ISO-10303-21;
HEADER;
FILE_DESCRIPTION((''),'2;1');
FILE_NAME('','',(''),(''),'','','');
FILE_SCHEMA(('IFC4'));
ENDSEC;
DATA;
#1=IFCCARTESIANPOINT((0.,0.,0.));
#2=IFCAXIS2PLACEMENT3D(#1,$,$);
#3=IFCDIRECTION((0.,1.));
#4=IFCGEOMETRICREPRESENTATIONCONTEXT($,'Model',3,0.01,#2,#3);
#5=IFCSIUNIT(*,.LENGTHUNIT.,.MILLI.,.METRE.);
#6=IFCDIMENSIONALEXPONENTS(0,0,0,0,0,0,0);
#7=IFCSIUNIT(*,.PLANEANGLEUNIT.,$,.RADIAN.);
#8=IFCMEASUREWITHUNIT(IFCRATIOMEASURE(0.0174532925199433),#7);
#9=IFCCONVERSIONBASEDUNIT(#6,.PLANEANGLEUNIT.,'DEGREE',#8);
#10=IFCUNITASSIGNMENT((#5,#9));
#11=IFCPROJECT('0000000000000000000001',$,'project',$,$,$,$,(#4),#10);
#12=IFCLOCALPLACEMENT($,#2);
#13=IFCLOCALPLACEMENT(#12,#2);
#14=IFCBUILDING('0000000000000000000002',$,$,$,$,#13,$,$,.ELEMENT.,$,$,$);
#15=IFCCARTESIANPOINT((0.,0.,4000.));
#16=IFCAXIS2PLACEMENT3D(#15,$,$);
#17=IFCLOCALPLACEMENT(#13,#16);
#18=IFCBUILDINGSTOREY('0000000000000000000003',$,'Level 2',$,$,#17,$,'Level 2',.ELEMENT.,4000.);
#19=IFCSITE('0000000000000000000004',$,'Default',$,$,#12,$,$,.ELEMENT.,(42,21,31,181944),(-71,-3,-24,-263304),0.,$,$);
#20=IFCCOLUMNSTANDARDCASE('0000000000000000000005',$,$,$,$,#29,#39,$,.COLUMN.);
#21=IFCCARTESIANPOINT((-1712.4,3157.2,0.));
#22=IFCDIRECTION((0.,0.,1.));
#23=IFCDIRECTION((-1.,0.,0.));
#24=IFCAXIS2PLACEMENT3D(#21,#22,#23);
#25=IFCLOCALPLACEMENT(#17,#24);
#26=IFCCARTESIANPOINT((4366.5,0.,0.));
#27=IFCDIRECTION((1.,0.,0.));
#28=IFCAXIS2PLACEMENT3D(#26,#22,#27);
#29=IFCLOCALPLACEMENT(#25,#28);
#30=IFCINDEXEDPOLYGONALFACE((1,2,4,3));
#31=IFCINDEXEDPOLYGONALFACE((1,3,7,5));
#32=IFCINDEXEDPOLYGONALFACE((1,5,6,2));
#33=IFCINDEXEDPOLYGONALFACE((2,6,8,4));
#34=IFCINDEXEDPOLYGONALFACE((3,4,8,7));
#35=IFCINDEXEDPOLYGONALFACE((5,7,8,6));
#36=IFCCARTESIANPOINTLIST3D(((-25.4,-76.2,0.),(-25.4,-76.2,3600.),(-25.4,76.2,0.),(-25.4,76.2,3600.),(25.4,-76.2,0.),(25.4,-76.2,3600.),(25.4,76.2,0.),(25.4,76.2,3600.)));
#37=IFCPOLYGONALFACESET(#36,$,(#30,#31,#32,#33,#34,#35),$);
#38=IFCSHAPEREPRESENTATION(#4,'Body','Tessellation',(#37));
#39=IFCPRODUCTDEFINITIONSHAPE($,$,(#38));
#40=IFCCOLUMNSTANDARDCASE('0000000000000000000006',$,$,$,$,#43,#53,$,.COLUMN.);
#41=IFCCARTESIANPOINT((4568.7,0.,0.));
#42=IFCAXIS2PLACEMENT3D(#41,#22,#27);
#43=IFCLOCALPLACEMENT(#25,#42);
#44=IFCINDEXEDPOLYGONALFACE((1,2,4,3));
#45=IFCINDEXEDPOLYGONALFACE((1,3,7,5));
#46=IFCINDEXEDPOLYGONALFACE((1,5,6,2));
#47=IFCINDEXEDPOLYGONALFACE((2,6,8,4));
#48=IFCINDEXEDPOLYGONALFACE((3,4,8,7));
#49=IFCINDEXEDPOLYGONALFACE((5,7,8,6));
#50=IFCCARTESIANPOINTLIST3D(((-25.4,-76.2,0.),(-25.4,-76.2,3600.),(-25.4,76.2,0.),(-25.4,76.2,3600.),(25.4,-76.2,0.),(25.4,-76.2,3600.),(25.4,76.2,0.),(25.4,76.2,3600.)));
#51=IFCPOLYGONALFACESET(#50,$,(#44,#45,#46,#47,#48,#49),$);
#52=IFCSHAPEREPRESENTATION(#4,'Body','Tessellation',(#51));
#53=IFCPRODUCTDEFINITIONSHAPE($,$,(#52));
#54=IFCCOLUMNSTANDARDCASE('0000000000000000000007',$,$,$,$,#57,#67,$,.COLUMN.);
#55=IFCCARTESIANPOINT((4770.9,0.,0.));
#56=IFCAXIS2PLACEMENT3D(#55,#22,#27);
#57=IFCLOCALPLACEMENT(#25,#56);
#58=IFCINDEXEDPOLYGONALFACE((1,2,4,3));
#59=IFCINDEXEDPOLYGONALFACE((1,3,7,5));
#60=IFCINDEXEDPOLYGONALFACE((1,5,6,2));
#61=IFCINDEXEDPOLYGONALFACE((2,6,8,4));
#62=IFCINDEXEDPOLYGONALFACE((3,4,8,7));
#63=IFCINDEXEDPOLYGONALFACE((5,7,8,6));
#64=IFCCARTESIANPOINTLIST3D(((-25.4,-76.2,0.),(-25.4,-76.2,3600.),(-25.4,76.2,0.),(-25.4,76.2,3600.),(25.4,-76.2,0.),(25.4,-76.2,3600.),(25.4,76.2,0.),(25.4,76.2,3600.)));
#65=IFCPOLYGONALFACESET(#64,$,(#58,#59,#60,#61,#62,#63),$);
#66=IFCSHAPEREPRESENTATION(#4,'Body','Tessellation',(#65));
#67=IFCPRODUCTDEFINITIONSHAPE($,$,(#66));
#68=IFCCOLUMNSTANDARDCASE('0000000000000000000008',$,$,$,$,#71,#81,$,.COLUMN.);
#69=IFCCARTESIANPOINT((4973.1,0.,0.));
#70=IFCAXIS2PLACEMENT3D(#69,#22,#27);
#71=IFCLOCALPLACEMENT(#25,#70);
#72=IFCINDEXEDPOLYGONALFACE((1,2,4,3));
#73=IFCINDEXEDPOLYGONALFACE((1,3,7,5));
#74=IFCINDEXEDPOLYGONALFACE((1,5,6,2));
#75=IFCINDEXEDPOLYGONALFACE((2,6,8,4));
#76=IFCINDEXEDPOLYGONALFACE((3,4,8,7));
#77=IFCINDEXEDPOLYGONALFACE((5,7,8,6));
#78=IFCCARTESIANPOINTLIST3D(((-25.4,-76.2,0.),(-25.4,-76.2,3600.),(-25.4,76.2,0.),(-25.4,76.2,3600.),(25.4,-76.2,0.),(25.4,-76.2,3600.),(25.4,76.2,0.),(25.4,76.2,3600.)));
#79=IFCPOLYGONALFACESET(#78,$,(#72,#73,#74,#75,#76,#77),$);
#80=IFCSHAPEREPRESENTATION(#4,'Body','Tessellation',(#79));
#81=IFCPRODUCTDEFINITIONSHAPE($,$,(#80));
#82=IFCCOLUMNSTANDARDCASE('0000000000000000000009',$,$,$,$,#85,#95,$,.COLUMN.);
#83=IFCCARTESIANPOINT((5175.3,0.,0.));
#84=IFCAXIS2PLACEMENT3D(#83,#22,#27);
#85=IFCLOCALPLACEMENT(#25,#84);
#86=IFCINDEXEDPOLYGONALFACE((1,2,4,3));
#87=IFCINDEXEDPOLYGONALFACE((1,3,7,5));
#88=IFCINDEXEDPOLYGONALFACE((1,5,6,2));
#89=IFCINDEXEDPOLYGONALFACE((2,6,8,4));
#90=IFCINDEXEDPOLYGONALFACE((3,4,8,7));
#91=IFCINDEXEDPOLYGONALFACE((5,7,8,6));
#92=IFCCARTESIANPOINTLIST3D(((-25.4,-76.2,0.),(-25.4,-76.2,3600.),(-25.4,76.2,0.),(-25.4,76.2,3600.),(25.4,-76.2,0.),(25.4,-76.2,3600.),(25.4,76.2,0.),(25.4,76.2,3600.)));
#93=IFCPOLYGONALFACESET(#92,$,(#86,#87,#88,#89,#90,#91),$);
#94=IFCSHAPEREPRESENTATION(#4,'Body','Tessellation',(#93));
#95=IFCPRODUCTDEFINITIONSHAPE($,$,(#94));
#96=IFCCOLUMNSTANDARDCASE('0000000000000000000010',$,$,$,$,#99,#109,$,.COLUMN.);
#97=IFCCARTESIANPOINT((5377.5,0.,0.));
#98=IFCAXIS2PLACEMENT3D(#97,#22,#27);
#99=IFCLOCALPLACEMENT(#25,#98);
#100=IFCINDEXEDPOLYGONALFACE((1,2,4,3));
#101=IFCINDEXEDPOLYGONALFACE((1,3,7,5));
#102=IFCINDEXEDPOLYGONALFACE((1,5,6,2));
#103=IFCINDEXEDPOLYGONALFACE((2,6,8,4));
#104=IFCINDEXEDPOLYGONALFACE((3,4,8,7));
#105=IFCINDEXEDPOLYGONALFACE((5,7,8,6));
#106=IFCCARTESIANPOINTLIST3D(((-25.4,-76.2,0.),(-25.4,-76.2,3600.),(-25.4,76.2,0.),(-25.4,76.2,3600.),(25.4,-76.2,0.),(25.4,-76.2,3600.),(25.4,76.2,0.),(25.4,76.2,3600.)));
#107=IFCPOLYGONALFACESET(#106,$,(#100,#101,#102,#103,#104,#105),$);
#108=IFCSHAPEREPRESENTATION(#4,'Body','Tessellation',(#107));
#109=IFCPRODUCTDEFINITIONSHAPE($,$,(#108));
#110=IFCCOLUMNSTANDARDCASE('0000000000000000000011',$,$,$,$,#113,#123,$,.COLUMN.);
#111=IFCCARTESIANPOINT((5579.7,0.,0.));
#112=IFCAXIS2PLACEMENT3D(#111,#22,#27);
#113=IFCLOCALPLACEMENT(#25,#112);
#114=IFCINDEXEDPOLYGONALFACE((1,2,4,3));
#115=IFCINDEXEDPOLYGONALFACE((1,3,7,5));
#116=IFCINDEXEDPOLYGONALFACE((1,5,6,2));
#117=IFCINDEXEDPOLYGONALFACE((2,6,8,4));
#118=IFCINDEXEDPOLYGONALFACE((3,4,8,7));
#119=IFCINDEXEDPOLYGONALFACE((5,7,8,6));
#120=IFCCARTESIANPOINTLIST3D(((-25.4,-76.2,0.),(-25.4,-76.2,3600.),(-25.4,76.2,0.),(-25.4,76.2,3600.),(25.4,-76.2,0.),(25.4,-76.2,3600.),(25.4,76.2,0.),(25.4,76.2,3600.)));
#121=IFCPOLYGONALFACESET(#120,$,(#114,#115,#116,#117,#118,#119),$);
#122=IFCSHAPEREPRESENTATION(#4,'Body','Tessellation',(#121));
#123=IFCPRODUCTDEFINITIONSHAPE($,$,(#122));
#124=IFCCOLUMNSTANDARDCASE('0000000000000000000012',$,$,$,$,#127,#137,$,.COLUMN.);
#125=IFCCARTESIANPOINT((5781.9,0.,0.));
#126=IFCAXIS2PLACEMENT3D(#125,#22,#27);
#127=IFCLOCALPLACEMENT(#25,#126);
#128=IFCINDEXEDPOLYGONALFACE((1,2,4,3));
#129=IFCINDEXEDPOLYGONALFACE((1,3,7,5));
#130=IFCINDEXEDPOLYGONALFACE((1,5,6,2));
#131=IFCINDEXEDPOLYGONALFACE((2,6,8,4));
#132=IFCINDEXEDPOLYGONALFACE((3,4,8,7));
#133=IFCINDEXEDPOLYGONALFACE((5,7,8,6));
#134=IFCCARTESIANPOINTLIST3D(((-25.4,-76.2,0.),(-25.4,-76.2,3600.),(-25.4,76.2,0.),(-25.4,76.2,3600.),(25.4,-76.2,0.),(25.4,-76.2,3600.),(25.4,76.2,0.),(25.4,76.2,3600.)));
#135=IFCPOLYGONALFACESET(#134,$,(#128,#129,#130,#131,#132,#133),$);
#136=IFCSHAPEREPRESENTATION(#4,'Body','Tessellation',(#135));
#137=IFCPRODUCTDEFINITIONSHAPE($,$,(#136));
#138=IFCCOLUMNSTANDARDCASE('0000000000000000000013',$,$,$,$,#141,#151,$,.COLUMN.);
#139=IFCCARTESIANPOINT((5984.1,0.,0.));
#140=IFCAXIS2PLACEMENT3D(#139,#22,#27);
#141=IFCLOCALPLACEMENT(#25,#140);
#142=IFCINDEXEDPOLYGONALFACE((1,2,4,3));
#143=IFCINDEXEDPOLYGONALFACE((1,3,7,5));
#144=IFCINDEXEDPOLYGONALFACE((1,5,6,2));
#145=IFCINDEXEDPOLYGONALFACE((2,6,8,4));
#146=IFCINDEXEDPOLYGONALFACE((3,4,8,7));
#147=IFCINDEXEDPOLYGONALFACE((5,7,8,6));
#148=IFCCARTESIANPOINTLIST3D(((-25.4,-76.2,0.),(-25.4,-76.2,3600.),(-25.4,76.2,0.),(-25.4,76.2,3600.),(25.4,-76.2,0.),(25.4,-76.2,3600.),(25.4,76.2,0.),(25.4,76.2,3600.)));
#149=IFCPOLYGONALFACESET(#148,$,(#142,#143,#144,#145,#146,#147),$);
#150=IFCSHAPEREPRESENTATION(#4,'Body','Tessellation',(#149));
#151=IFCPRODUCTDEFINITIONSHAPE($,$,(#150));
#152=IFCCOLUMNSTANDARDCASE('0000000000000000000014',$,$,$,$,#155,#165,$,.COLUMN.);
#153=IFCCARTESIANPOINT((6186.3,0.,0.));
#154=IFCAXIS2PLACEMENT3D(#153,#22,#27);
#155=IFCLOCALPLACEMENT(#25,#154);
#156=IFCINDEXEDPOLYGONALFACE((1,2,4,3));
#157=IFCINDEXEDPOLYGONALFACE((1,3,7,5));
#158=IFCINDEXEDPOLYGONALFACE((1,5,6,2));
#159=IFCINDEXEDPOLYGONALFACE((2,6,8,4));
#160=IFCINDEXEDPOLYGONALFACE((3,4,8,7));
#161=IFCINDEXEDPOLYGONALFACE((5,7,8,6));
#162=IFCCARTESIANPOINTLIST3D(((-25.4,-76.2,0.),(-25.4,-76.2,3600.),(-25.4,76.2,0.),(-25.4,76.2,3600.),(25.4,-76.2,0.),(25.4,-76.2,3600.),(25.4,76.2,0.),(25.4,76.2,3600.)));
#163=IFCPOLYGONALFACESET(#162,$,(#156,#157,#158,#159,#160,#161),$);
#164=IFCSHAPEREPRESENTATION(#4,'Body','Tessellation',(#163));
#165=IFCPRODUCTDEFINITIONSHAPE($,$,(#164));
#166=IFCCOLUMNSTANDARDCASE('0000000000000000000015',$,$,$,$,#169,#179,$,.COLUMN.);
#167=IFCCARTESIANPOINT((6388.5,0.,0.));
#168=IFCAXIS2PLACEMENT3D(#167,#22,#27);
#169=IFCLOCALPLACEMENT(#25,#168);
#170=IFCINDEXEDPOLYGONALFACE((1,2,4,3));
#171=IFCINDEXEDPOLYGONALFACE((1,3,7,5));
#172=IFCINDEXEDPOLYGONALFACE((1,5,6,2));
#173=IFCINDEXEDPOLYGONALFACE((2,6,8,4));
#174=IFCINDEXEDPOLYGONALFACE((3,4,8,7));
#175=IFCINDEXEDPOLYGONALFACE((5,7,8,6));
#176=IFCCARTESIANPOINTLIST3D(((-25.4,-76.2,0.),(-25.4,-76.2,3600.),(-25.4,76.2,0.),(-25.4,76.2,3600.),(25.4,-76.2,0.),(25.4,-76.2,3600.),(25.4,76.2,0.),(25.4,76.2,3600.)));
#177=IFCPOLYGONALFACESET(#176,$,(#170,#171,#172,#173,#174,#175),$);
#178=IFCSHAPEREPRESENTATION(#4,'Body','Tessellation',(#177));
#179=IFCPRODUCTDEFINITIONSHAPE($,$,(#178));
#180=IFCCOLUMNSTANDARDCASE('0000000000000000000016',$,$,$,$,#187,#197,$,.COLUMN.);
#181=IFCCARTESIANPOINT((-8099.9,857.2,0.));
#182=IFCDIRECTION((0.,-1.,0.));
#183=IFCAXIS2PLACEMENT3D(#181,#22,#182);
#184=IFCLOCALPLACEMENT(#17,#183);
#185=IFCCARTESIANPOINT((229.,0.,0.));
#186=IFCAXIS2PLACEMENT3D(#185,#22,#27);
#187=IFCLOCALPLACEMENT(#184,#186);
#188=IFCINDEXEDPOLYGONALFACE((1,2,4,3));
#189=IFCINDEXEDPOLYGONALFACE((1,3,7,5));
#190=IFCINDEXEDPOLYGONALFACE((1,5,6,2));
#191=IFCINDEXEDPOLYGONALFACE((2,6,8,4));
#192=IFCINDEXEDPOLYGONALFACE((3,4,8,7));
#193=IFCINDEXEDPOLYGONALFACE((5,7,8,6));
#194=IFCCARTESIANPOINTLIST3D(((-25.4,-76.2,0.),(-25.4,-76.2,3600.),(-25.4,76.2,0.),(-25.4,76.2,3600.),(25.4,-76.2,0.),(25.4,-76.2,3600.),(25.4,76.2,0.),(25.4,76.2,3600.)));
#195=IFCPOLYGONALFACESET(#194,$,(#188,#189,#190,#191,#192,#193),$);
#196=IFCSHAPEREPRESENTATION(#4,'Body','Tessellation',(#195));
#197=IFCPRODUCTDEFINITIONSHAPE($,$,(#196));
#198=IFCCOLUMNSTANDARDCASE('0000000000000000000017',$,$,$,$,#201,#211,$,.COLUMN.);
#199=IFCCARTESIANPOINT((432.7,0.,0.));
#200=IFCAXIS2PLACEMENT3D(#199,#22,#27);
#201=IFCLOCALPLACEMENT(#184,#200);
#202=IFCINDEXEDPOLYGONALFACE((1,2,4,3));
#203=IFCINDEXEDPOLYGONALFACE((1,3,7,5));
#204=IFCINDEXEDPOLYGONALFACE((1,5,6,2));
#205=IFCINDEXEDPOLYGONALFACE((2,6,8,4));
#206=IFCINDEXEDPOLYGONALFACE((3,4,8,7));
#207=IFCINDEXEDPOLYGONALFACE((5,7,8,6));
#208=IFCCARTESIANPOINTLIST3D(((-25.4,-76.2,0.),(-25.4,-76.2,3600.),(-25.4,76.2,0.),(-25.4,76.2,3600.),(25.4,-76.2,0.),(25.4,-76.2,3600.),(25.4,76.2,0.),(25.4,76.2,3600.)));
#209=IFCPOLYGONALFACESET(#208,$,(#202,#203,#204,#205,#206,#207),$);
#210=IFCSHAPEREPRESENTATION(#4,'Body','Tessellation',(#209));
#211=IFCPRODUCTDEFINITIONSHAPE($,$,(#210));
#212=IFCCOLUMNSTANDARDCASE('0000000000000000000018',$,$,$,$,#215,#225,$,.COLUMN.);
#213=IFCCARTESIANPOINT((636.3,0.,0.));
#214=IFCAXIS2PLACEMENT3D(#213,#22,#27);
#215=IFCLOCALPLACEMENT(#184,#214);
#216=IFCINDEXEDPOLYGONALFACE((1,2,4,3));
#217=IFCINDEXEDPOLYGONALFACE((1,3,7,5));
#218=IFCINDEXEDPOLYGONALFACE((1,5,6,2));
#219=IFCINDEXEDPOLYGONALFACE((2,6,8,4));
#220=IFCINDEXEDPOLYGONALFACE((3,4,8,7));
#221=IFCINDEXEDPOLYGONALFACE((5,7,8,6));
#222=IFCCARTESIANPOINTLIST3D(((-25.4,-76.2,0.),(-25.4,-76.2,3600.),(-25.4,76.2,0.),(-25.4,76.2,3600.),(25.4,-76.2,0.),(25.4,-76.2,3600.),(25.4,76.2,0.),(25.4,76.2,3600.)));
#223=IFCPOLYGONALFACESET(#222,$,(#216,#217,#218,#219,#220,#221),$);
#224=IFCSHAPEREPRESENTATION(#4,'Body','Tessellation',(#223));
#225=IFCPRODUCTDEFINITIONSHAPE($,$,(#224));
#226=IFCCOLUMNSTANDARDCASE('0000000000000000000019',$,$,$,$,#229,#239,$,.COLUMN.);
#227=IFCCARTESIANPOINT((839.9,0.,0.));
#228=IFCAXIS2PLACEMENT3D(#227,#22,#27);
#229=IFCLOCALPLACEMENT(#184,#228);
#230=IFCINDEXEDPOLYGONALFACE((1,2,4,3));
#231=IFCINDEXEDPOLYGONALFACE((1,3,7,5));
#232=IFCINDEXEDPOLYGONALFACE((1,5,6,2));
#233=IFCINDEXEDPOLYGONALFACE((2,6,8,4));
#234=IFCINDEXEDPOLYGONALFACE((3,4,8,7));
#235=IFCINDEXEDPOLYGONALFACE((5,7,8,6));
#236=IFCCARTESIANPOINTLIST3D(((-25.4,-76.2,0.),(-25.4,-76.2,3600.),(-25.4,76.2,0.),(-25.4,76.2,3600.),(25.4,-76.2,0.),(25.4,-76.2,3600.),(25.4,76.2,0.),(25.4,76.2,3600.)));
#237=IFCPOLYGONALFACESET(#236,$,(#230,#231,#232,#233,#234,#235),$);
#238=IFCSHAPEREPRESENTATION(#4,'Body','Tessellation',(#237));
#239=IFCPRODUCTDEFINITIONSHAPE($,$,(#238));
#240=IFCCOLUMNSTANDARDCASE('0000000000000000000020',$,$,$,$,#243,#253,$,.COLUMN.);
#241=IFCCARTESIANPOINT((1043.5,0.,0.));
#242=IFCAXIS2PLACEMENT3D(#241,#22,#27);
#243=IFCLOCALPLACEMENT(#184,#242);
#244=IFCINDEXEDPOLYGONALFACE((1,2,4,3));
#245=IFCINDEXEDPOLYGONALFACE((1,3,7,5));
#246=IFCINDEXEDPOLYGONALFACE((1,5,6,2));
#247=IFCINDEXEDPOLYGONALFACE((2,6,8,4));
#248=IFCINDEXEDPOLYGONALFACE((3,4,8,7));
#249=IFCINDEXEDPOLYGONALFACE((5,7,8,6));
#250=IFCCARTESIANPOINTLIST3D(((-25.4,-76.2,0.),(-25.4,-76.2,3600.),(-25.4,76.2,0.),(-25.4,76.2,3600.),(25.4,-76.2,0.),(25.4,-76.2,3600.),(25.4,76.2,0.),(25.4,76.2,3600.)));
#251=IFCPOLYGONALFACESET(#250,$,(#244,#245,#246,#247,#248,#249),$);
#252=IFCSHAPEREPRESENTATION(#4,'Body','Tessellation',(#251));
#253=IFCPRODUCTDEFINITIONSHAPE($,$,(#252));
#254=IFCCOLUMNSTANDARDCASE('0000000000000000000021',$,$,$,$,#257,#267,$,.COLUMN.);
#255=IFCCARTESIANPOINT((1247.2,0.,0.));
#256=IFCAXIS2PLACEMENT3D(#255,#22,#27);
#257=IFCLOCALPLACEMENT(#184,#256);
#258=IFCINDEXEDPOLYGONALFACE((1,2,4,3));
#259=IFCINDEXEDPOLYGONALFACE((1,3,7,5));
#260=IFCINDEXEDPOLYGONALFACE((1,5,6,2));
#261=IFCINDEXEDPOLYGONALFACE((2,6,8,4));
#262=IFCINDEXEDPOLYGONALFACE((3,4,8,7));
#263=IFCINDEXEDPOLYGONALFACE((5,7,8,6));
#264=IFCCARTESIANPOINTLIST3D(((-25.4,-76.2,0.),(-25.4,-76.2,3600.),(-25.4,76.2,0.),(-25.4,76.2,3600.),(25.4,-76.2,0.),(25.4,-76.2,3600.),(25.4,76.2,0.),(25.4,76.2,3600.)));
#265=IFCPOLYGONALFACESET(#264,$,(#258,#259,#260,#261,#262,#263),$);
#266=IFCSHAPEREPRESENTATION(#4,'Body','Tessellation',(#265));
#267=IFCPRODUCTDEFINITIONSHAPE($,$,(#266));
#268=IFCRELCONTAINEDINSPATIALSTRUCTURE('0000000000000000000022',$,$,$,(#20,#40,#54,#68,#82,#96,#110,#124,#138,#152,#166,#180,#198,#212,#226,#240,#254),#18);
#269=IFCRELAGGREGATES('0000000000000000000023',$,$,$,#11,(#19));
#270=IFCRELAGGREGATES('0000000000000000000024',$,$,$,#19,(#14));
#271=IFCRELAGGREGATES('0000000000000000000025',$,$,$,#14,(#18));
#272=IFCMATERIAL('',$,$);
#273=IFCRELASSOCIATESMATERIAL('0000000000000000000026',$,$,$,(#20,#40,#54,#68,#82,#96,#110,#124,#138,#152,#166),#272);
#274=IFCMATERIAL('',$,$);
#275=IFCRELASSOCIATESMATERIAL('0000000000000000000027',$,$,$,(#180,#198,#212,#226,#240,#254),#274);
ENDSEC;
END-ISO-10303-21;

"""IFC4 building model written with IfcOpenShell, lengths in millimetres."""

from ifc_helpers import new_model, entity, si_unit, converted_unit, direction, frame, origin, place, context, project, spatial, rectangle, extrude, material, element, save


model = new_model("IFC4")

# Units and contexts
model_context = context("Model", 3, precision=0.01, world=origin(), true_north=direction((0.0, 1.0)))
ifc_project = project(units=[si_unit("LENGTHUNIT", "METRE", prefix="MILLI"), converted_unit("PLANEANGLEUNIT", "DEGREE", entity("IfcRatioMeasure", 0.0174532925199433), si_unit("PLANEANGLEUNIT", "RADIAN"), dimensions=[0, 0, 0, 0, 0, 0, 0])], contexts=[model_context])

# Site, building, storey
site_placement = place(None, origin())
site = spatial("IfcSite", under=ifc_project, at=site_placement, Name="Default", CompositionType="ELEMENT", RefLatitude=(42, 21, 31, 181944), RefLongitude=(-71, -3, -24, -263304), RefElevation=0.0)
building_placement = place(site_placement, origin())
building = spatial("IfcBuilding", under=site, at=building_placement, CompositionType="ELEMENT")
storey_placement = place(building_placement, frame((0.0, 0.0, 4000.0)))
storey = spatial("IfcBuildingStorey", under=building, at=storey_placement, Name="Level 2", LongName="Level 2", CompositionType="ELEMENT", Elevation=4000.0)

# Columns
ifc_material_1 = material(Name="")
placement_1 = place(storey_placement, frame((-1712.4, 3157.2, 0.0), z_axis=(0.0, 0.0, 1.0), x_axis=(-1.0, 0.0, 0.0)))
for number, where, z_axis, x_axis in (
    (1, (4366.5, 0.0, 0.0), (0.0, 0.0, 1.0), (1.0, 0.0, 0.0)),
    (2, (4568.7, 0.0, 0.0), (0.0, 0.0, 1.0), (1.0, 0.0, 0.0)),
    (3, (4770.9, 0.0, 0.0), (0.0, 0.0, 1.0), (1.0, 0.0, 0.0)),
    (4, (4973.1, 0.0, 0.0), (0.0, 0.0, 1.0), (1.0, 0.0, 0.0)),
    (5, (5175.3, 0.0, 0.0), (0.0, 0.0, 1.0), (1.0, 0.0, 0.0)),
    (6, (5377.5, 0.0, 0.0), (0.0, 0.0, 1.0), (1.0, 0.0, 0.0)),
    (7, (5579.7, 0.0, 0.0), (0.0, 0.0, 1.0), (1.0, 0.0, 0.0)),
    (8, (5781.9, 0.0, 0.0), (0.0, 0.0, 1.0), (1.0, 0.0, 0.0)),
    (9, (5984.1, 0.0, 0.0), (0.0, 0.0, 1.0), (1.0, 0.0, 0.0)),
    (10, (6186.3, 0.0, 0.0), (0.0, 0.0, 1.0), (1.0, 0.0, 0.0)),
    (11, (6388.5, 0.0, 0.0), (0.0, 0.0, 1.0), (1.0, 0.0, 0.0)),
):
    element("IfcColumnStandardCase", number, at=place(placement_1, frame(where, z_axis=z_axis, x_axis=x_axis)), inside=storey, material=ifc_material_1, PredefinedType="COLUMN", context=model_context, shape_type="SweptSolid", body=[
        extrude(rectangle(XDim=50.8, YDim=152.4), origin(), (0.0, 0.0, 1.0), 3600.0),
    ])
ifc_material_2 = material(Name="")
placement_2 = place(storey_placement, frame((-8099.9, 857.2, 0.0), z_axis=(0.0, 0.0, 1.0), x_axis=(0.0, -1.0, 0.0)))
for number, where, z_axis, x_axis in (
    (12, (229.0, 0.0, 0.0), (0.0, 0.0, 1.0), (1.0, 0.0, 0.0)),
    (13, (432.7, 0.0, 0.0), (0.0, 0.0, 1.0), (1.0, 0.0, 0.0)),
    (14, (636.3, 0.0, 0.0), (0.0, 0.0, 1.0), (1.0, 0.0, 0.0)),
    (15, (839.9, 0.0, 0.0), (0.0, 0.0, 1.0), (1.0, 0.0, 0.0)),
    (16, (1043.5, 0.0, 0.0), (0.0, 0.0, 1.0), (1.0, 0.0, 0.0)),
    (17, (1247.2, 0.0, 0.0), (0.0, 0.0, 1.0), (1.0, 0.0, 0.0)),
):
    element("IfcColumnStandardCase", number, at=place(placement_2, frame(where, z_axis=z_axis, x_axis=x_axis)), inside=storey, material=ifc_material_2, PredefinedType="COLUMN", context=model_context, shape_type="SweptSolid", body=[
        extrude(rectangle(XDim=50.8, YDim=152.4), origin(), (0.0, 0.0, 1.0), 3600.0),
    ])

save(model, "model.ifc")
